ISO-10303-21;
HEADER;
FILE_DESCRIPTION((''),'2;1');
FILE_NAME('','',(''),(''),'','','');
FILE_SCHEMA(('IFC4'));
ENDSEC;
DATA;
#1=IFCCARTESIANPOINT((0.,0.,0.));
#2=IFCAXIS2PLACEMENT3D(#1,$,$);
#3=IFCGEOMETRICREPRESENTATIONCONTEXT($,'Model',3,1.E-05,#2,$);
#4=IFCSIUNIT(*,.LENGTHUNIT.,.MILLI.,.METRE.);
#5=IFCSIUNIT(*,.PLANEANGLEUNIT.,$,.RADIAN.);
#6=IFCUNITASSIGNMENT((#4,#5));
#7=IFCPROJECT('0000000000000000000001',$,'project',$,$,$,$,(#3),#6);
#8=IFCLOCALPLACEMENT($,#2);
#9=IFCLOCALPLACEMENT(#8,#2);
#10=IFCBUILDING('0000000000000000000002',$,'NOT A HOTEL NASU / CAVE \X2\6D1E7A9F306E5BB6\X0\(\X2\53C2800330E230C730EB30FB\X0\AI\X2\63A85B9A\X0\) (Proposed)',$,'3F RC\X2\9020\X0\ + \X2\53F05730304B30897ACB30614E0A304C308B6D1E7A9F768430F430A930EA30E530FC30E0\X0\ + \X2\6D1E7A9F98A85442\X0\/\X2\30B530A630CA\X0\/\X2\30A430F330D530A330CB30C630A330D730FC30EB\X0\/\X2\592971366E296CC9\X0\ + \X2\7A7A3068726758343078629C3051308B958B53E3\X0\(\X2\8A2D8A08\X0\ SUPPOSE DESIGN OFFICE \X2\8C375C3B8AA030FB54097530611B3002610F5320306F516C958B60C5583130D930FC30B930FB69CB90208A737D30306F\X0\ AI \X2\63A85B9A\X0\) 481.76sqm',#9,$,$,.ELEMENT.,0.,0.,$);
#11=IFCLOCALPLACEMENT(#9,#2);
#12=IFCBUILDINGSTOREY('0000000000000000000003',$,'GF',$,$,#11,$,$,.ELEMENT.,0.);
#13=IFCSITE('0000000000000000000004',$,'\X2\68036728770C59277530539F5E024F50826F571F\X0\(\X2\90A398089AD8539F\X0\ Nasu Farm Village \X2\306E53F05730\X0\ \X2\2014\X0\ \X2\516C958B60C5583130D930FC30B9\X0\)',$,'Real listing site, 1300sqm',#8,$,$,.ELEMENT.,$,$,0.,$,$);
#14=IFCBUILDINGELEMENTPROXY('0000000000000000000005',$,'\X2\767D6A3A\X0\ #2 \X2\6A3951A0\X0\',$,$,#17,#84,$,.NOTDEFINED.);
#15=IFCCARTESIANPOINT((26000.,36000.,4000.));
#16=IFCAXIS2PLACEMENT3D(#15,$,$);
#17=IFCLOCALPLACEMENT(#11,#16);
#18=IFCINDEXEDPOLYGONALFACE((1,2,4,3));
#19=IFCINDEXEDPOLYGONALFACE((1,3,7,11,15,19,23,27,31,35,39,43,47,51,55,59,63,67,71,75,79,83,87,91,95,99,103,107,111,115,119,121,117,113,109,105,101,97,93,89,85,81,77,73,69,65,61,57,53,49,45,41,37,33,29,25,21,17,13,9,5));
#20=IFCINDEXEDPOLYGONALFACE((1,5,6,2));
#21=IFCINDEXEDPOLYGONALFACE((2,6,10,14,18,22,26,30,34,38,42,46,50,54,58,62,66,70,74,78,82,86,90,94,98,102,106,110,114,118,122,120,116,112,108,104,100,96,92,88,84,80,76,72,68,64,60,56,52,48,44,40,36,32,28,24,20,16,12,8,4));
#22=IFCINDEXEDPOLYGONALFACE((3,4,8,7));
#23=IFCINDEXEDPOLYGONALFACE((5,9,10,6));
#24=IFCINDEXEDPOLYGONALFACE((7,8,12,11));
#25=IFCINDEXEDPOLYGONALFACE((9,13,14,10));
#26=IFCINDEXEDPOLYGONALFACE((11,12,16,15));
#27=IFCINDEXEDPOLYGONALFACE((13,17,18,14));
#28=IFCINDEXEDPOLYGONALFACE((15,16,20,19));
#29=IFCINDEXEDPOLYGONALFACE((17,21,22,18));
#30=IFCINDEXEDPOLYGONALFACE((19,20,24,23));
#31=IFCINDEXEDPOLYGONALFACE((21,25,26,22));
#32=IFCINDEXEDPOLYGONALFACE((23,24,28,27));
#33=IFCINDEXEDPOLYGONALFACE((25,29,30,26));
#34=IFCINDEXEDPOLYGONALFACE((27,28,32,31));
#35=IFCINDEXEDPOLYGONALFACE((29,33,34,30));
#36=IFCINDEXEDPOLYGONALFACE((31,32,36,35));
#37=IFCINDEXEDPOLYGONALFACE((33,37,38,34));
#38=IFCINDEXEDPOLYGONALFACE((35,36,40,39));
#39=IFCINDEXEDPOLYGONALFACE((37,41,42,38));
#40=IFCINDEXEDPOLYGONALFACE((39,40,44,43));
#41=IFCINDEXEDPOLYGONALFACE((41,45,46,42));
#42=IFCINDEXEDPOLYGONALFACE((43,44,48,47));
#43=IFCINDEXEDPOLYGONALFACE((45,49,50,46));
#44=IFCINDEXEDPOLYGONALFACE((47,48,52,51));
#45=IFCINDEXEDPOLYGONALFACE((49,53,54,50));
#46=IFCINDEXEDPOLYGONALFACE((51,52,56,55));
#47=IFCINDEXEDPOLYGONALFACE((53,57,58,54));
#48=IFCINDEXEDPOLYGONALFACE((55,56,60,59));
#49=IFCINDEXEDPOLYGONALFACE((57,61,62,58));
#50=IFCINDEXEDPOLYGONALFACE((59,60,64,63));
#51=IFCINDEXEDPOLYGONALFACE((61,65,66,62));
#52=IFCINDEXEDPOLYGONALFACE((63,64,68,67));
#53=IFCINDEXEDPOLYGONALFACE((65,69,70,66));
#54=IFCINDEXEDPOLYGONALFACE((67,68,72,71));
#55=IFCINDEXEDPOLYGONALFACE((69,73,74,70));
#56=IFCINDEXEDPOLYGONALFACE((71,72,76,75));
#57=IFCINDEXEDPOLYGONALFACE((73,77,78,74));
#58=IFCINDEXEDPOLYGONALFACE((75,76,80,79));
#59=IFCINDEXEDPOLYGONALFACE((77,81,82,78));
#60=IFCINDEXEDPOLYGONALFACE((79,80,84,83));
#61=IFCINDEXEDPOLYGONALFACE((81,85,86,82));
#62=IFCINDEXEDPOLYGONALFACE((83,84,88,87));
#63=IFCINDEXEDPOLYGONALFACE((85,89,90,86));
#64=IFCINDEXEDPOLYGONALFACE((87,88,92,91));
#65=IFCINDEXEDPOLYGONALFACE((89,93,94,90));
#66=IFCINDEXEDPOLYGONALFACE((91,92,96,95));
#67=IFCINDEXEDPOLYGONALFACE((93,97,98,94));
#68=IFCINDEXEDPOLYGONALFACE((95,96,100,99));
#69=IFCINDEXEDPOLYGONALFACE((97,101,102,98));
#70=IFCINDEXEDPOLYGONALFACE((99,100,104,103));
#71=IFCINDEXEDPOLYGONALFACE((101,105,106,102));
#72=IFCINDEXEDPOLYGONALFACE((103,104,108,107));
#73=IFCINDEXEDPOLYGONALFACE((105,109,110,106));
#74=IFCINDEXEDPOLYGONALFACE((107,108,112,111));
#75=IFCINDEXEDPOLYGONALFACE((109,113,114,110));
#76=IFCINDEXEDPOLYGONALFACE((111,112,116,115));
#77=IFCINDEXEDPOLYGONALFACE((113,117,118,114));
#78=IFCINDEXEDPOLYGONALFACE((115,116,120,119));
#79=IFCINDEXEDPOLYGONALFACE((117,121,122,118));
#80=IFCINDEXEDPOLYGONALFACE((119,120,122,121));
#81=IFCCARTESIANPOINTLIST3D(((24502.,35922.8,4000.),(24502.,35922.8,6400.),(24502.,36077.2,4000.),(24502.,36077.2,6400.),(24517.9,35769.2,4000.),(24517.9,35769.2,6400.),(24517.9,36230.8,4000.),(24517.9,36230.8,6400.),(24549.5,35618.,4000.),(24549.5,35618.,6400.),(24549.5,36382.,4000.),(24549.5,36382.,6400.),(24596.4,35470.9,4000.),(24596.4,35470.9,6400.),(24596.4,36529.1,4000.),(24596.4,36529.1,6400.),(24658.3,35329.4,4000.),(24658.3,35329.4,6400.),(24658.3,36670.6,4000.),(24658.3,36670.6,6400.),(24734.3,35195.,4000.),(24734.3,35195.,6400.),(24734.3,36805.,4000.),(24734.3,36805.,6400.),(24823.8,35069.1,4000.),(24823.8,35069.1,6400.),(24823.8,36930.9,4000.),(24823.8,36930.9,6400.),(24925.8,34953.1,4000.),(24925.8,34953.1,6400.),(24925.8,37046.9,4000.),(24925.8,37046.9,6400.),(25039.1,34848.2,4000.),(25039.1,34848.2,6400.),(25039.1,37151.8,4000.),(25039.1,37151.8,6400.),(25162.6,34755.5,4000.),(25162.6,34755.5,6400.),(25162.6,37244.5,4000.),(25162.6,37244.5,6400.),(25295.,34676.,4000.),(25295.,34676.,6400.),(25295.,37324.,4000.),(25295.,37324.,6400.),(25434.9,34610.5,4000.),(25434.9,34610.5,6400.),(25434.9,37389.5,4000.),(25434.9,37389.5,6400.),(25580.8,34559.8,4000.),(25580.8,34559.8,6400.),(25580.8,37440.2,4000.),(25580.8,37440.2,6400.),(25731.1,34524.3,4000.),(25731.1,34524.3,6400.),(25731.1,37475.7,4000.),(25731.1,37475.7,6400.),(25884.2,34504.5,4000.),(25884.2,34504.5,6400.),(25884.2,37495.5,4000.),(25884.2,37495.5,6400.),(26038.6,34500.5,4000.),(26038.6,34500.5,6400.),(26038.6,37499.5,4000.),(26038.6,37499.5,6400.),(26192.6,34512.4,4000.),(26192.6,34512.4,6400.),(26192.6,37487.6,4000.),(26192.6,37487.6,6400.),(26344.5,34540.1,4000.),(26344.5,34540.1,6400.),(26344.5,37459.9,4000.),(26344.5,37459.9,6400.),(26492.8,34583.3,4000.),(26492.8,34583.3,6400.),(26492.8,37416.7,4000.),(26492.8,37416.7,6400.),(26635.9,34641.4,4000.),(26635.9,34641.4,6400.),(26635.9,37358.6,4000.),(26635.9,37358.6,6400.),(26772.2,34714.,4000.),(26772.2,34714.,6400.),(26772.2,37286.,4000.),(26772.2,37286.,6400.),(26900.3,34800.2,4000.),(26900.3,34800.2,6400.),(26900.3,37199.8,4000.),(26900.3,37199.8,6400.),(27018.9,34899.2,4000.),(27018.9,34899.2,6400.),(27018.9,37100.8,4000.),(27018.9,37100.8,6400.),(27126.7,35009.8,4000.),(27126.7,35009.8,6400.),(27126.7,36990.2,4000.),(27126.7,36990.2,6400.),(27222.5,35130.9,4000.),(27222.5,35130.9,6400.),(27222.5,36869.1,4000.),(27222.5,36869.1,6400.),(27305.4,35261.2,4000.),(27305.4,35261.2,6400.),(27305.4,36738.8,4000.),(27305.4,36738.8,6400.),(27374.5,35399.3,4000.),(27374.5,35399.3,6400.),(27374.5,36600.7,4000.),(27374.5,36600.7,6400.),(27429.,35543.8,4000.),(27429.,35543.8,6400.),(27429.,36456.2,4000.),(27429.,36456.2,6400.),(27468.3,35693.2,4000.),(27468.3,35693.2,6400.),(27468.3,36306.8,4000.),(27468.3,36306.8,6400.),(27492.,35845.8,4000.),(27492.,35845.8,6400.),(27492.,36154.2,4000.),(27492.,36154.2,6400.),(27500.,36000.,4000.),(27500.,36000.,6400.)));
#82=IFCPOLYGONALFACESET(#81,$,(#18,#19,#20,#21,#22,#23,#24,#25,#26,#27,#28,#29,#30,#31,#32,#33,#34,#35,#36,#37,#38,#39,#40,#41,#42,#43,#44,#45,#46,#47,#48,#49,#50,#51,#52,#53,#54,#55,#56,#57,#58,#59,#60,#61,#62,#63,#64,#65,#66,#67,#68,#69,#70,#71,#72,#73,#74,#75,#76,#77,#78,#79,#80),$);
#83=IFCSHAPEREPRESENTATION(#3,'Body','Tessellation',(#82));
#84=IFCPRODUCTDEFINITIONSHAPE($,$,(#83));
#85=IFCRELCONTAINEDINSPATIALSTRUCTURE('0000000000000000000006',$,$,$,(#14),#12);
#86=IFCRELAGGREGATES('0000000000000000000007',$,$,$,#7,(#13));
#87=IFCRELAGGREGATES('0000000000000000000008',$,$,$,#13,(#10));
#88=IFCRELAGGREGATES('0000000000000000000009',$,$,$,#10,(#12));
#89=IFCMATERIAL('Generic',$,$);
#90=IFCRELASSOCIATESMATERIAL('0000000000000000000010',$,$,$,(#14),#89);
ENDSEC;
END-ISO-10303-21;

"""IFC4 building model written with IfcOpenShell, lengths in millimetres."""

from ifc_helpers import new_model, si_unit, frame, origin, origin_2d, place, context, project, spatial, circle, extrude, material, element, save


model = new_model("IFC4")

# Units and contexts
model_context = context("Model", 3, precision=1e-05, world=origin())
ifc_project = project(units=[si_unit("LENGTHUNIT", "METRE", prefix="MILLI"), si_unit("PLANEANGLEUNIT", "RADIAN")], contexts=[model_context])

# Site, building, storey
site_placement = place(None, origin())
site = spatial("IfcSite", under=ifc_project, at=site_placement, Name="栃木県大田原市佐良土(那須高原 Nasu Farm Village の台地 — 公開情報ベース)", ObjectType="Real listing site, 1300sqm", CompositionType="ELEMENT", RefElevation=0.0)
building_placement = place(site_placement, origin())
building = spatial("IfcBuilding", under=site, at=building_placement, Name="NOT A HOTEL NASU / CAVE 洞窟の家(参考モデル・AI推定) (Proposed)", ObjectType="3F RC造 + 台地から立ち上がる洞窟的ヴォリューム + 洞窟風呂/サウナ/インフィニティプール/天然温泉 + 空と牧場へ抜ける開口(設計 SUPPOSE DESIGN OFFICE 谷尻誠・吉田愛。意匠は公開情報ベース・構造詳細は AI 推定) 481.76sqm", CompositionType="ELEMENT", ElevationOfRefHeight=0.0, ElevationOfTerrain=0.0)
storey_placement = place(building_placement, origin())
storey = spatial("IfcBuildingStorey", under=building, at=storey_placement, Name="GF", CompositionType="ELEMENT", Elevation=0.0)

# Shared definitions
ifc_material_1 = material(Name="Generic")

# Building element proxy
proxy_1_placement = place(storey_placement, frame((26000.0, 36000.0, 4000.0)))
element("IfcBuildingElementProxy", 1, at=proxy_1_placement, inside=storey, material=ifc_material_1, Name="白樺 #2 樹冠", PredefinedType="NOTDEFINED", context=model_context, shape_type="SweptSolid", body=[
    extrude(circle(Radius=1500.0, at=origin_2d()), frame((26000.0, 36000.0, 4000.0)), (0.0, 0.0, 1.0), 2400.0),
])

save(model, "model.ifc")
